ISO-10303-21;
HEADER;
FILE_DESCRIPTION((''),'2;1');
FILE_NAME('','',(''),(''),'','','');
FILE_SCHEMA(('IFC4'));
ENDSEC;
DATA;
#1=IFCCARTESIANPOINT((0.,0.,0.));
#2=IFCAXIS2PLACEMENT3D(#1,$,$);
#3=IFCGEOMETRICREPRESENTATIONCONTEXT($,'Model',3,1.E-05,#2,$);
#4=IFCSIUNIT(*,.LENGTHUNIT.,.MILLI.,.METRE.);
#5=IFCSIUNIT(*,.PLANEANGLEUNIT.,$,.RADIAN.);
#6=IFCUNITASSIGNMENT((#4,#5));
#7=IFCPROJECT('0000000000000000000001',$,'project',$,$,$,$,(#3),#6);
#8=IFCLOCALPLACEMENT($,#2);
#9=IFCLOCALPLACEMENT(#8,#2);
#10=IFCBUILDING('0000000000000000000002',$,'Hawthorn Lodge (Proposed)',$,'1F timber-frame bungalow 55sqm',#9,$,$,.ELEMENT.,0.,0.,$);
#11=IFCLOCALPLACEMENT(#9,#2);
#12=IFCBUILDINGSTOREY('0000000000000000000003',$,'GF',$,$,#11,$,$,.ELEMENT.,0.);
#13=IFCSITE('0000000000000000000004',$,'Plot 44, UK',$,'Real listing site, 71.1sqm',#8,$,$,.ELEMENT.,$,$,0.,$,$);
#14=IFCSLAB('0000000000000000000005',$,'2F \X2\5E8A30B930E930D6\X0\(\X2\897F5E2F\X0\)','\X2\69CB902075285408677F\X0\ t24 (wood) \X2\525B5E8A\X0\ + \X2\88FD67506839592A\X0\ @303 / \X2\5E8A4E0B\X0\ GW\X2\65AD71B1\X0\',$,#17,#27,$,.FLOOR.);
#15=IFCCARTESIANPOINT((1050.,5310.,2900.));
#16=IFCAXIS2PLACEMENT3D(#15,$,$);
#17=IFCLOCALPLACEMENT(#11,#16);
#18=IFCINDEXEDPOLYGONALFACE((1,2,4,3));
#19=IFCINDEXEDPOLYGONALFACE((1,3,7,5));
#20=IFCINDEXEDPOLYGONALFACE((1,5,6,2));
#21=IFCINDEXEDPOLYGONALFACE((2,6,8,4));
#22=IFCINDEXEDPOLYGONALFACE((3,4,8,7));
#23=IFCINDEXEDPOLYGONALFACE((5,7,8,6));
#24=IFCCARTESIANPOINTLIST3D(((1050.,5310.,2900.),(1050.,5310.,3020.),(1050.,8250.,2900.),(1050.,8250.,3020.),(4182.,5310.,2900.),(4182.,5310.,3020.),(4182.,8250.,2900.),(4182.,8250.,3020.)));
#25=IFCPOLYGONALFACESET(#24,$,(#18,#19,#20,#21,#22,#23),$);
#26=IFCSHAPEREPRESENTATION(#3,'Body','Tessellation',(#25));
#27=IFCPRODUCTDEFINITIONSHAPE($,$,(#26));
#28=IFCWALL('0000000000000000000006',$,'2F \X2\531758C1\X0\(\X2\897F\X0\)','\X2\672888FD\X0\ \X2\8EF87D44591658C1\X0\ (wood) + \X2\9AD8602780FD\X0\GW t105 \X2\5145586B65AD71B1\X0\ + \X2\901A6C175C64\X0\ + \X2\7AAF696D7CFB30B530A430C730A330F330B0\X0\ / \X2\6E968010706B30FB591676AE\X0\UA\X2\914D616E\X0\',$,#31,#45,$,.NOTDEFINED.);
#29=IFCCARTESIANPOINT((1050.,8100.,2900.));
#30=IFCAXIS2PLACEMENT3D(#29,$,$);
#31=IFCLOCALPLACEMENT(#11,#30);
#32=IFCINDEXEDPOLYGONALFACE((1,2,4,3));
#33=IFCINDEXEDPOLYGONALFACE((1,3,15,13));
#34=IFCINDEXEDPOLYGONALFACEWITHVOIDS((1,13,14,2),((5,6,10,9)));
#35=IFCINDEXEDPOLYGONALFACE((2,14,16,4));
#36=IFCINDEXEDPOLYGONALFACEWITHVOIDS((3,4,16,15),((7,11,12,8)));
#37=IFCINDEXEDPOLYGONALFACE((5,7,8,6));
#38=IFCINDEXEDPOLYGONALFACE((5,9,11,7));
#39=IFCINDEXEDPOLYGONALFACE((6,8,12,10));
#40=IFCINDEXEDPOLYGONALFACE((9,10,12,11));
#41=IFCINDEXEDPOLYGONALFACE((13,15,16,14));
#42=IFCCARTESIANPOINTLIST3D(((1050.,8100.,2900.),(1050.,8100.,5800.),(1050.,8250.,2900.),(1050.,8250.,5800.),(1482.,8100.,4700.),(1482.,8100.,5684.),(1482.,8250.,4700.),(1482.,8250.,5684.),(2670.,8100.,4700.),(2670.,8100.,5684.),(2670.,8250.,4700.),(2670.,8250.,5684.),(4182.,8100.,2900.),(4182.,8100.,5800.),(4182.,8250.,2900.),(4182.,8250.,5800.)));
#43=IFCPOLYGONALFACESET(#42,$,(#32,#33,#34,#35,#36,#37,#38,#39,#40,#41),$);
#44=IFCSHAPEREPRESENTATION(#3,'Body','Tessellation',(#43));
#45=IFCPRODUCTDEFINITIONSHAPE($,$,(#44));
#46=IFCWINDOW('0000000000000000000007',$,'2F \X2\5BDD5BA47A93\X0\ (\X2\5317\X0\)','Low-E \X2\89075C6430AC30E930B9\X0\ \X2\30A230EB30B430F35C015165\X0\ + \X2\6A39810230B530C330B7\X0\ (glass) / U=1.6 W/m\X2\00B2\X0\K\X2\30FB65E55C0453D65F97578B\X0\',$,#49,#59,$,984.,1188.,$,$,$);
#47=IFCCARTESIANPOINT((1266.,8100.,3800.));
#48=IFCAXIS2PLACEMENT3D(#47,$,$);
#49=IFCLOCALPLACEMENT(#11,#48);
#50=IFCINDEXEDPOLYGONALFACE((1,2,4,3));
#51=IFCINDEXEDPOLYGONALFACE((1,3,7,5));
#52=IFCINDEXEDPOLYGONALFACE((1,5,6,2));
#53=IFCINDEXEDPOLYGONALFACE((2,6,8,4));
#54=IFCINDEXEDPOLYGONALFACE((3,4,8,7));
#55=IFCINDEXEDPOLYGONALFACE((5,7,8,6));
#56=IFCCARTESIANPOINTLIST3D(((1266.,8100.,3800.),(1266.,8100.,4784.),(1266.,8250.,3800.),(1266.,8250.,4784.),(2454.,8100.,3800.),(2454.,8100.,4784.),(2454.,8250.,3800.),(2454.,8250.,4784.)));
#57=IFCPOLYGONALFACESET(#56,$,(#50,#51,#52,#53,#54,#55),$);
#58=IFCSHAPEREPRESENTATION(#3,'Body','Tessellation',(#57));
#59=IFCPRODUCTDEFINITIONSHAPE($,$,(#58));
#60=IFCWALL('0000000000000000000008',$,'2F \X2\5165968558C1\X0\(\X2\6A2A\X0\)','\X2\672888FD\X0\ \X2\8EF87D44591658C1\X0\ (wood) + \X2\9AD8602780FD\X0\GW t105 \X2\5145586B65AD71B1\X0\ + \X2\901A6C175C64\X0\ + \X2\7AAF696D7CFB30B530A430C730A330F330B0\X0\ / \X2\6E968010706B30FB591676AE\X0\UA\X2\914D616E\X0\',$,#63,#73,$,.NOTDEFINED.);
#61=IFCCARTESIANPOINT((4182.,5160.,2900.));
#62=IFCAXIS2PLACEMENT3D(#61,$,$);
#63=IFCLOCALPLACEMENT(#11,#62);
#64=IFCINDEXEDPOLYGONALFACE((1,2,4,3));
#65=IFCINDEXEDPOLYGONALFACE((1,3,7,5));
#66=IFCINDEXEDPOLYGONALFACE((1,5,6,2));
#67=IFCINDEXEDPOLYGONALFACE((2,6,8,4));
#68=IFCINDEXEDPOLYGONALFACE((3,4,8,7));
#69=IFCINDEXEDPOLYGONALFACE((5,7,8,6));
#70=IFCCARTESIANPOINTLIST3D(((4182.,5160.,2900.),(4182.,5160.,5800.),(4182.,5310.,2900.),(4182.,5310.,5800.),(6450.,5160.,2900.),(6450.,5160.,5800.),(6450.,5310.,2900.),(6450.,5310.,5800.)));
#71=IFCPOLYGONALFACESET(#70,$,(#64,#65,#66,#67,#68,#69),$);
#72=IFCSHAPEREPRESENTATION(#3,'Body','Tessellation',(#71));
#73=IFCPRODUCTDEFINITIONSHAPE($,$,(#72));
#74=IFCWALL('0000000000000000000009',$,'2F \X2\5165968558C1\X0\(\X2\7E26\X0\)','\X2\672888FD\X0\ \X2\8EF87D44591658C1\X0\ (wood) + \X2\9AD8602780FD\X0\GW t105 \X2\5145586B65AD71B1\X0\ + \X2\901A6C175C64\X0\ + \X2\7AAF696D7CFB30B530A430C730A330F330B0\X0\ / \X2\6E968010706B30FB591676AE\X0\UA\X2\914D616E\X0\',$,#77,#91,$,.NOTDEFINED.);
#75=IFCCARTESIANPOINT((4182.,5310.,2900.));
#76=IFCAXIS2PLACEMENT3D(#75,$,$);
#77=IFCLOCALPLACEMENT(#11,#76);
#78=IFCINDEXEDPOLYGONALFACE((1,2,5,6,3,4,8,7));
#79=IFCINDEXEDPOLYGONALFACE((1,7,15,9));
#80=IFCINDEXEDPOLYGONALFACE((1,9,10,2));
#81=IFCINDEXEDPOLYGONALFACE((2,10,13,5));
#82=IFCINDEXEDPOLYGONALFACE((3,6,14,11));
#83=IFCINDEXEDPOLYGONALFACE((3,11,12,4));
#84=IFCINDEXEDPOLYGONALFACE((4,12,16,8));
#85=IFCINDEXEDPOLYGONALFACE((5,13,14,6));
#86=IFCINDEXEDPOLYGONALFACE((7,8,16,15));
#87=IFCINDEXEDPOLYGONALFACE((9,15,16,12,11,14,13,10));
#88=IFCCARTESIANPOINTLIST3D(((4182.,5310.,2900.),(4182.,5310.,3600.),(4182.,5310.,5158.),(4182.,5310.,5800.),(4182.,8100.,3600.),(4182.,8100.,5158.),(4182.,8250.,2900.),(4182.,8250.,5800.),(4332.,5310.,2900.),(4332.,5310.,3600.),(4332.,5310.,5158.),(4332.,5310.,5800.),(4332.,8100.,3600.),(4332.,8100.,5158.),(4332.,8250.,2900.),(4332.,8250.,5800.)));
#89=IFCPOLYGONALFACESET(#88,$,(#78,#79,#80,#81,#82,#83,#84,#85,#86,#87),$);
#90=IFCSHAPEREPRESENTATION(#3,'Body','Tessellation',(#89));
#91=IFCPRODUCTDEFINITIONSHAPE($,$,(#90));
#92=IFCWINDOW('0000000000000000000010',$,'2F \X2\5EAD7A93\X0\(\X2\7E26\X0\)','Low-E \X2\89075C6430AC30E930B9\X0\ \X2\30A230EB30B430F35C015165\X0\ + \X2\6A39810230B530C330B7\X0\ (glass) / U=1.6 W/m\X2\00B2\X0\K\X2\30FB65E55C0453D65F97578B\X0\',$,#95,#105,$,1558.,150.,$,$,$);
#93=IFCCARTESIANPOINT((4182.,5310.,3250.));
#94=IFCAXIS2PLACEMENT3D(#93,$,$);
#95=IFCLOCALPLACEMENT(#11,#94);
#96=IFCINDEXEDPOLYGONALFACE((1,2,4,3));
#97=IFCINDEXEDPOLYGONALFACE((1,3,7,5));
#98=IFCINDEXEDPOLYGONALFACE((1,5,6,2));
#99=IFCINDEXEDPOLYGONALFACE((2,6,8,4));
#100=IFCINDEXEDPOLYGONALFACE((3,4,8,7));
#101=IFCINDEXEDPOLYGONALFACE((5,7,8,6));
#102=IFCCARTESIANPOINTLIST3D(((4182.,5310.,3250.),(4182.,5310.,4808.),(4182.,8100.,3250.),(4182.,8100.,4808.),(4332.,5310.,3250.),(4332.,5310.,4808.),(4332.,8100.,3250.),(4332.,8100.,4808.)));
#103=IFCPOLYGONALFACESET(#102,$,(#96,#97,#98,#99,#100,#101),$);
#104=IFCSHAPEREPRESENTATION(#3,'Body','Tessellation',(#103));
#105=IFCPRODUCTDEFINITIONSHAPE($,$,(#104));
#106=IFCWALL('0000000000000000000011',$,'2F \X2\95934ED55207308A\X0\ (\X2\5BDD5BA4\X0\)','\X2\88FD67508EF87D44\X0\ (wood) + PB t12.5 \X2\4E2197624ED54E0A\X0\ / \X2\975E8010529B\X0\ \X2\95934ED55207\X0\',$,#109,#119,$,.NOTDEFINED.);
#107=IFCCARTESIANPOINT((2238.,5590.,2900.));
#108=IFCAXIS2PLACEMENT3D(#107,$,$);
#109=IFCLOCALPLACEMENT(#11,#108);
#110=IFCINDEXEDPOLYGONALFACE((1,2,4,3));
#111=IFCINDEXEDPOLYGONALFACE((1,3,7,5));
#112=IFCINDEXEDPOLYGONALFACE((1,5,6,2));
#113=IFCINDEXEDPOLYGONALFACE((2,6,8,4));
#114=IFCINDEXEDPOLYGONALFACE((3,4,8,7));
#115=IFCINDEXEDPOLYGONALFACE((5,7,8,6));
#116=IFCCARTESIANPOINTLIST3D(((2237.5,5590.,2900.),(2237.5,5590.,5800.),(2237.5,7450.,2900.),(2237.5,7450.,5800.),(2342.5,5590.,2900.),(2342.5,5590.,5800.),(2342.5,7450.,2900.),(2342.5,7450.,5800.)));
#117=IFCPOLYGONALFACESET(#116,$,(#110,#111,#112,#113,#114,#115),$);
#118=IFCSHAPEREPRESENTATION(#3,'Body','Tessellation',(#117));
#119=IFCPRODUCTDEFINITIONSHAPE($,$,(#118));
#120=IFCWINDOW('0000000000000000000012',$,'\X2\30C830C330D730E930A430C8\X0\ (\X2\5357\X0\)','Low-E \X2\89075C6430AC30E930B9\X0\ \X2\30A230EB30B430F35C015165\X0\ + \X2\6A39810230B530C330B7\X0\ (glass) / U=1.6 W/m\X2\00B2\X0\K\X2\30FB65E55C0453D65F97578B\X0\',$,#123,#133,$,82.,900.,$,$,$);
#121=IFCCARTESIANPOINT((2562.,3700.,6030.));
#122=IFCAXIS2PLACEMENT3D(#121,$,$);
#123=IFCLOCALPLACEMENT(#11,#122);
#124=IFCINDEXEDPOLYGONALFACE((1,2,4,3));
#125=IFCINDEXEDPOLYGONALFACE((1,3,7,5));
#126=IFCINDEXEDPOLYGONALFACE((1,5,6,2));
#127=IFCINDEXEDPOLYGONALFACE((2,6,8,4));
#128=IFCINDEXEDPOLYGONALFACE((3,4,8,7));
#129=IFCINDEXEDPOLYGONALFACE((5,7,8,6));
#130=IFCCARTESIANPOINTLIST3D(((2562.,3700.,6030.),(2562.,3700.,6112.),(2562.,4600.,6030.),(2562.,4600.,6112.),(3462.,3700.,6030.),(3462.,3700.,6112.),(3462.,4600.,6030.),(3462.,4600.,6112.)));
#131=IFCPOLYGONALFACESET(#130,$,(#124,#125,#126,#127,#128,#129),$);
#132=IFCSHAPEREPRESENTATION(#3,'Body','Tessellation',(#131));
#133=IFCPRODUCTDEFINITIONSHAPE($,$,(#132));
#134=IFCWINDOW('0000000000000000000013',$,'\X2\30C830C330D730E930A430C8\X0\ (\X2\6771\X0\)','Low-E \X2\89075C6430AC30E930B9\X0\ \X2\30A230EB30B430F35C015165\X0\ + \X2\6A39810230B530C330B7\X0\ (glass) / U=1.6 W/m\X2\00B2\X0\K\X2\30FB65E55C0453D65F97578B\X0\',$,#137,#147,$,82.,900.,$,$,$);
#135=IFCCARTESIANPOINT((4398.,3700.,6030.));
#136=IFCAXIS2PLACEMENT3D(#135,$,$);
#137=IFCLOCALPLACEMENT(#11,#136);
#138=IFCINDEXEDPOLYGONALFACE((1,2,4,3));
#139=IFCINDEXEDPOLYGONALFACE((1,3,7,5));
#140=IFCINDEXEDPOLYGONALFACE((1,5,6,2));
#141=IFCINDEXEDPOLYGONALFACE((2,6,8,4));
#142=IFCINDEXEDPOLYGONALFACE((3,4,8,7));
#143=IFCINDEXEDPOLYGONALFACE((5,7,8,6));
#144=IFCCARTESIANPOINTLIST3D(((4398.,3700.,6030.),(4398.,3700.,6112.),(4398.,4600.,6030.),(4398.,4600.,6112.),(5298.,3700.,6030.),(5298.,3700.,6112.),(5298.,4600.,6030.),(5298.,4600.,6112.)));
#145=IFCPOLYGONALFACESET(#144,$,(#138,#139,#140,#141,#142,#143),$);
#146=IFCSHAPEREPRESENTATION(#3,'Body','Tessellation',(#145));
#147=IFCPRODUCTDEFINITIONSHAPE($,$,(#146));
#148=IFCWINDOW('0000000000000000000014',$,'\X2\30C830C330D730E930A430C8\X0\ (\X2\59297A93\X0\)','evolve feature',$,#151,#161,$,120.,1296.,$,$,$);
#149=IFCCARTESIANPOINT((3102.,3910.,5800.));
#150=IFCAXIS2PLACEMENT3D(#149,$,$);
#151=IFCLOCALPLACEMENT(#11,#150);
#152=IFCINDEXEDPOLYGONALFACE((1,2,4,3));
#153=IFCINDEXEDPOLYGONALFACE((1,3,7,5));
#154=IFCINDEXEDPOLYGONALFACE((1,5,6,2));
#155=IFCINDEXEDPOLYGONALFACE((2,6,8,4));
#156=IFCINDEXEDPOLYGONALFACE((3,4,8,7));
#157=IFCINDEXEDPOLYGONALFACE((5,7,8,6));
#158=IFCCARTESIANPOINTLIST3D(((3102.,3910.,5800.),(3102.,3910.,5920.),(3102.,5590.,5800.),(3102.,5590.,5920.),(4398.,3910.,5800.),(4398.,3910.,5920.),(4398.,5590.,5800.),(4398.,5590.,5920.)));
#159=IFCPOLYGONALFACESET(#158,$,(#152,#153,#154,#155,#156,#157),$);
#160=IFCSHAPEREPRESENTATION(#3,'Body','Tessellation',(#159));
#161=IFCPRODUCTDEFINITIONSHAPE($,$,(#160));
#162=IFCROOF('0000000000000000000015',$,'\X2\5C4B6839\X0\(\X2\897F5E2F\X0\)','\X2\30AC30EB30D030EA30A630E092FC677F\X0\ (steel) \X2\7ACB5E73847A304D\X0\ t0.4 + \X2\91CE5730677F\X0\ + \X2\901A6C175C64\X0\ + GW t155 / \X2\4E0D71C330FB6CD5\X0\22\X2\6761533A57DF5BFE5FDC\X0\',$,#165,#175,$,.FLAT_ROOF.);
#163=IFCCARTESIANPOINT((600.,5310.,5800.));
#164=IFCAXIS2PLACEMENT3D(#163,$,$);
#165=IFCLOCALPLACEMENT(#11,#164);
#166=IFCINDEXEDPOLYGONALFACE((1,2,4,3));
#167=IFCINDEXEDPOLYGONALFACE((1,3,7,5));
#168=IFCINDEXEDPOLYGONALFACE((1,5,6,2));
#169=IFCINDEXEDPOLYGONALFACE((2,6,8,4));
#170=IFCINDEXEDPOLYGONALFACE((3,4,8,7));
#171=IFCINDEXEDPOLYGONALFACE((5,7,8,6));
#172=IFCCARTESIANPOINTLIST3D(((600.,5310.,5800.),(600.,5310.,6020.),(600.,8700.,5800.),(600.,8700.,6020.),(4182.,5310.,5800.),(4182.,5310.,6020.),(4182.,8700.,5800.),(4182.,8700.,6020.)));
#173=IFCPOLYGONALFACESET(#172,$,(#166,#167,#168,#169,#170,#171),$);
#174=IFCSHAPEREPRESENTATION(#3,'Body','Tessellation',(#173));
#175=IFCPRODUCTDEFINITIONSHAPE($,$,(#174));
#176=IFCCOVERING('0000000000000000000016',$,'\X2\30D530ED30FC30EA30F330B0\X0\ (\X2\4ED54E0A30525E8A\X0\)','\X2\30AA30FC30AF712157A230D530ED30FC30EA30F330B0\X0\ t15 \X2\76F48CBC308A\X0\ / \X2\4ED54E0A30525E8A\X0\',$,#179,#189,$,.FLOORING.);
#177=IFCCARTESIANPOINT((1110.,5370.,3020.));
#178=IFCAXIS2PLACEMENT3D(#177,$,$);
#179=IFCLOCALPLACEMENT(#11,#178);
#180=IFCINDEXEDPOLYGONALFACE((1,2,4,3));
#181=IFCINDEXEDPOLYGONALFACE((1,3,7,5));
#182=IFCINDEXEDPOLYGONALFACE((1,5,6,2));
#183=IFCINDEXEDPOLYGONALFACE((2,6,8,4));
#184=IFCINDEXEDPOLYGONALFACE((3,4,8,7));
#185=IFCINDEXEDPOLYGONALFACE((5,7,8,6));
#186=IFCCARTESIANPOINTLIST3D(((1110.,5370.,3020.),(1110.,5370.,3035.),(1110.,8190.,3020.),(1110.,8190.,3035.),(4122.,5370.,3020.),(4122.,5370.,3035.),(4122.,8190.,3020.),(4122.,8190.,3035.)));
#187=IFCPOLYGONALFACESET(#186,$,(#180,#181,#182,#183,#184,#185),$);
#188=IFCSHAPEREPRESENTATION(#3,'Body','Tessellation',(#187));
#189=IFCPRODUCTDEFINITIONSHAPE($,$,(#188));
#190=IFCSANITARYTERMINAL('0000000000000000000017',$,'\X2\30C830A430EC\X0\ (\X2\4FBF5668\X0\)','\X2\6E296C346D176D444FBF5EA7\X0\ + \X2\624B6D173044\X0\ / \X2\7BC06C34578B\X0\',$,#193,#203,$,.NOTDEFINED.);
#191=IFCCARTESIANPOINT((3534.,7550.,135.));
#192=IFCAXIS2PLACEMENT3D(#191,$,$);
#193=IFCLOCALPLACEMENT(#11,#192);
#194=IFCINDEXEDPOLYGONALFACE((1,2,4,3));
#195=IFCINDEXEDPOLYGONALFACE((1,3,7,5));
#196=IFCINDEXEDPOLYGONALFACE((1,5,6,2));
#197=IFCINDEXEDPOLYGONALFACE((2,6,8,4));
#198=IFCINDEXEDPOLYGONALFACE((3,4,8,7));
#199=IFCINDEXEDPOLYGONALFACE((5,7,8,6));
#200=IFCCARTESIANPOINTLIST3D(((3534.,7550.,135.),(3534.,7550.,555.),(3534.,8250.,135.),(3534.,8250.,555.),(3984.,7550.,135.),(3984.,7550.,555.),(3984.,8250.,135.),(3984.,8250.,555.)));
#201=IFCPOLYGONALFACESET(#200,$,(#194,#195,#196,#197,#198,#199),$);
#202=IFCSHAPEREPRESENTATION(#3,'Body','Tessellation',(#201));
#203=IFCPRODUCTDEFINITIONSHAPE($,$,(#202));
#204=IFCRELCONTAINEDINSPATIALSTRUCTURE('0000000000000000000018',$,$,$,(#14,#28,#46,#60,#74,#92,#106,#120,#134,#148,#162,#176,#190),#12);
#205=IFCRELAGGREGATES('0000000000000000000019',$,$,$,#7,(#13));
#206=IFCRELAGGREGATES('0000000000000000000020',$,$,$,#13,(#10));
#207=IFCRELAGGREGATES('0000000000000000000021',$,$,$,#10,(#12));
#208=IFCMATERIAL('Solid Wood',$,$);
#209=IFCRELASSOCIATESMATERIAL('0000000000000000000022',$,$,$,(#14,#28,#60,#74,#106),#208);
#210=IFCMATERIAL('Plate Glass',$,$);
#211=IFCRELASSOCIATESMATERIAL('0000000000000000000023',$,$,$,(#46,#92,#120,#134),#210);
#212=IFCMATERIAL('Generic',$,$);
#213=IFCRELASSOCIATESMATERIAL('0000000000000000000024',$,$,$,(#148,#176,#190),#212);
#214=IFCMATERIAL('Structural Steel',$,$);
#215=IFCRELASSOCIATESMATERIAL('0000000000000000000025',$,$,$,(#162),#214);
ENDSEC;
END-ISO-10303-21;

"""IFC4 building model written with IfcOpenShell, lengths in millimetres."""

from ifc_helpers import new_model, si_unit, frame, frame_2d, origin, place, context, project, spatial, rectangle, extrude, material, element, fill, save


model = new_model("IFC4")

# Units and contexts
model_context = context("Model", 3, precision=1e-05, world=origin())
ifc_project = project(units=[si_unit("LENGTHUNIT", "METRE", prefix="MILLI"), si_unit("PLANEANGLEUNIT", "RADIAN")], contexts=[model_context])

# Site, building, storey
site_placement = place(None, origin())
site = spatial("IfcSite", under=ifc_project, at=site_placement, Name="Plot 44, UK", ObjectType="Real listing site, 71.1sqm", CompositionType="ELEMENT", RefElevation=0.0)
building_placement = place(site_placement, origin())
building = spatial("IfcBuilding", under=site, at=building_placement, Name="Hawthorn Lodge (Proposed)", ObjectType="1F timber-frame bungalow 55sqm", CompositionType="ELEMENT", ElevationOfRefHeight=0.0, ElevationOfTerrain=0.0)
storey_placement = place(building_placement, origin())
storey = spatial("IfcBuildingStorey", under=building, at=storey_placement, Name="GF", CompositionType="ELEMENT", Elevation=0.0)

# Slab
ifc_material_1 = material(Name="Solid Wood")
slab_placement = place(storey_placement, frame((1050.0, 5310.0, 2900.0)))
element("IfcSlab", 1, at=slab_placement, inside=storey, material=ifc_material_1, Name="2F 床スラブ(西帯)", Description="構造用合板 t24 (wood) 剛床 + 製材根太 @303 / 床下 GW断熱", PredefinedType="FLOOR", context=model_context, shape_type="SweptSolid", body=[
    extrude(rectangle(XDim=3132.0, YDim=2940.0, at=frame_2d((1566.0, 1470.0))), frame((1050.0, 5310.0, 2900.0)), (0.0, 0.0, 1.0), 120.0),
])

# Wall, opening, window
wall_1_placement = place(storey_placement, frame((1050.0, 8100.0, 2900.0)))
wall_1 = element("IfcWall", 2, at=wall_1_placement, inside=storey, material=ifc_material_1, Name="2F 北壁(西)", Description="木製 軸組外壁 (wood) + 高性能GW t105 充填断熱 + 通気層 + 窯業系サイディング / 準耐火・外皮UA配慮", PredefinedType="NOTDEFINED", context=model_context, shape_type="SweptSolid", body=[
    extrude(rectangle(XDim=3132.0, YDim=150.0, at=frame_2d((1566.0, 75.0))), frame((1050.0, 8100.0, 2900.0)), (0.0, 0.0, 1.0), 2900.0),
])
opening_1_placement = place(storey_placement, frame((1266.0, 8100.0, 3800.0)))
opening_1 = element("IfcOpeningElement", 3, at=opening_1_placement, cuts=wall_1, PredefinedType="NOTDEFINED", context=model_context, shape_type="SweptSolid", body=[
    extrude(rectangle(XDim=1188.0, YDim=150.0, at=frame_2d((594.0, 75.0))), frame((1266.0, 8100.0, 3800.0)), (0.0, 0.0, 1.0), 984.0),
])
ifc_material_2 = material(Name="Plate Glass")
window_1_placement = place(storey_placement, frame((1266.0, 8100.0, 3800.0)))
window_1 = element("IfcWindow", 4, at=window_1_placement, inside=storey, material=ifc_material_2, Name="2F 寝室窓 (北)", Description="Low-E 複層ガラス アルゴン封入 + 樹脂サッシ (glass) / U=1.6 W/m²K・日射取得型", OverallHeight=984.0, OverallWidth=1188.0, context=model_context, shape_type="SweptSolid", body=[
    extrude(rectangle(XDim=1188.0, YDim=150.0, at=frame_2d((594.0, 75.0))), frame((1266.0, 8100.0, 3800.0)), (0.0, 0.0, 1.0), 984.0),
])
fill(opening_1, window_1)

# Wall
wall_2_placement = place(storey_placement, frame((4182.0, 5160.0, 2900.0)))
element("IfcWall", 5, at=wall_2_placement, inside=storey, material=ifc_material_1, Name="2F 入隅壁(横)", Description="木製 軸組外壁 (wood) + 高性能GW t105 充填断熱 + 通気層 + 窯業系サイディング / 準耐火・外皮UA配慮", PredefinedType="NOTDEFINED", context=model_context, shape_type="SweptSolid", body=[
    extrude(rectangle(XDim=2268.0, YDim=150.0, at=frame_2d((1134.0, 75.0))), frame((4182.0, 5160.0, 2900.0)), (0.0, 0.0, 1.0), 2900.0),
])

# Wall, opening, window
wall_3_placement = place(storey_placement, frame((4182.0, 5310.0, 2900.0)))
wall_3 = element("IfcWall", 6, at=wall_3_placement, inside=storey, material=ifc_material_1, Name="2F 入隅壁(縦)", Description="木製 軸組外壁 (wood) + 高性能GW t105 充填断熱 + 通気層 + 窯業系サイディング / 準耐火・外皮UA配慮", PredefinedType="NOTDEFINED", context=model_context, shape_type="SweptSolid", body=[
    extrude(rectangle(XDim=150.0, YDim=2940.0, at=frame_2d((75.0, 1470.0))), frame((4182.0, 5310.0, 2900.0)), (0.0, 0.0, 1.0), 2900.0),
])
opening_2_placement = place(storey_placement, frame((4182.0, 5310.0, 3250.0)))
opening_2 = element("IfcOpeningElement", 7, at=opening_2_placement, cuts=wall_3, PredefinedType="NOTDEFINED", context=model_context, shape_type="SweptSolid", body=[
    extrude(rectangle(XDim=150.0, YDim=2790.0, at=frame_2d((75.0, 1395.0))), frame((4182.0, 5310.0, 3250.0)), (0.0, 0.0, 1.0), 1558.0),
])
window_2_placement = place(storey_placement, frame((4182.0, 5310.0, 3250.0)))
window_2 = element("IfcWindow", 8, at=window_2_placement, inside=storey, material=ifc_material_2, Name="2F 庭窓(縦)", Description="Low-E 複層ガラス アルゴン封入 + 樹脂サッシ (glass) / U=1.6 W/m²K・日射取得型", OverallHeight=1558.0, OverallWidth=150.0, context=model_context, shape_type="SweptSolid", body=[
    extrude(rectangle(XDim=150.0, YDim=2790.0, at=frame_2d((75.0, 1395.0))), frame((4182.0, 5310.0, 3250.0)), (0.0, 0.0, 1.0), 1558.0),
])
fill(opening_2, window_2)

# Wall
wall_4_placement = place(storey_placement, frame((2238.0, 5590.0, 2900.0)))
element("IfcWall", 9, at=wall_4_placement, inside=storey, material=ifc_material_1, Name="2F 間仕切り (寝室)", Description="製材軸組 (wood) + PB t12.5 両面仕上 / 非耐力 間仕切", PredefinedType="NOTDEFINED", context=model_context, shape_type="SweptSolid", body=[
    extrude(rectangle(XDim=105.0, YDim=1860.0, at=frame_2d((52.0, 930.0))), frame((2238.0, 5590.0, 2900.0)), (0.0, 0.0, 1.0), 2900.0),
])

# Windows
window_3_placement = place(storey_placement, frame((2562.0, 3700.0, 6030.0)))
element("IfcWindow", 10, at=window_3_placement, inside=storey, material=ifc_material_2, Name="トップライト (南)", Description="Low-E 複層ガラス アルゴン封入 + 樹脂サッシ (glass) / U=1.6 W/m²K・日射取得型", OverallHeight=82.0, OverallWidth=900.0, context=model_context, shape_type="SweptSolid", body=[
    extrude(rectangle(XDim=900.0, YDim=900.0, at=frame_2d((450.0, 450.0))), frame((2562.0, 3700.0, 6030.0)), (0.0, 0.0, 1.0), 82.0),
])
window_4_placement = place(storey_placement, frame((4398.0, 3700.0, 6030.0)))
element("IfcWindow", 11, at=window_4_placement, inside=storey, material=ifc_material_2, Name="トップライト (東)", Description="Low-E 複層ガラス アルゴン封入 + 樹脂サッシ (glass) / U=1.6 W/m²K・日射取得型", OverallHeight=82.0, OverallWidth=900.0, context=model_context, shape_type="SweptSolid", body=[
    extrude(rectangle(XDim=900.0, YDim=900.0, at=frame_2d((450.0, 450.0))), frame((4398.0, 3700.0, 6030.0)), (0.0, 0.0, 1.0), 82.0),
])
ifc_material_3 = material(Name="Generic")
window_5_placement = place(storey_placement, frame((3102.0, 3910.0, 5800.0)))
element("IfcWindow", 12, at=window_5_placement, inside=storey, material=ifc_material_3, Name="トップライト (天窓)", Description="evolve feature", OverallHeight=120.0, OverallWidth=1296.0, context=model_context, shape_type="SweptSolid", body=[
    extrude(rectangle(XDim=1296.0, YDim=1680.0, at=frame_2d((648.0, 840.0))), frame((3102.0, 3910.0, 5800.0)), (0.0, 0.0, 1.0), 120.0),
])

# Roof
ifc_material_4 = material(Name="Structural Steel")
for number, where, name in (
    (13, (600.0, 5310.0, 5800.0), "屋根(西帯)"),
):
    element("IfcRoof", number, at=place(storey_placement, frame(where)), inside=storey, material=ifc_material_4, Name=name, Description="ガルバリウム鋼板 (steel) 立平葺き t0.4 + 野地板 + 通気層 + GW t155 / 不燃・法22条区域対応", PredefinedType="FLAT_ROOF", context=model_context, shape_type="SweptSolid", body=[
        extrude(rectangle(XDim=3582.0, YDim=3390.0, at=frame_2d((1791.0, 1695.0))), frame((600.0, 5310.0, 5800.0)), (0.0, 0.0, 1.0), 220.0),
    ])

# Covering
covering_placement = place(storey_placement, frame((1110.0, 5370.0, 3020.0)))
element("IfcCovering", 14, at=covering_placement, inside=storey, material=ifc_material_3, Name="フローリング (仕上げ床)", Description="オーク無垢フローリング t15 直貼り / 仕上げ床", PredefinedType="FLOORING", context=model_context, shape_type="SweptSolid", body=[
    extrude(rectangle(XDim=3012.0, YDim=2820.0, at=frame_2d((1506.0, 1410.0))), frame((1110.0, 5370.0, 3020.0)), (0.0, 0.0, 1.0), 15.0),
])

# Sanitary terminal
sanitary_terminal_placement = place(storey_placement, frame((3534.0, 7550.0, 135.0)))
element("IfcSanitaryTerminal", 15, at=sanitary_terminal_placement, inside=storey, material=ifc_material_3, Name="トイレ (便器)", Description="温水洗浄便座 + 手洗い / 節水型", PredefinedType="NOTDEFINED", context=model_context, shape_type="SweptSolid", body=[
    extrude(rectangle(XDim=450.0, YDim=700.0, at=frame_2d((225.0, 350.0))), frame((3534.0, 7550.0, 135.0)), (0.0, 0.0, 1.0), 420.0),
])

save(model, "model.ifc")
